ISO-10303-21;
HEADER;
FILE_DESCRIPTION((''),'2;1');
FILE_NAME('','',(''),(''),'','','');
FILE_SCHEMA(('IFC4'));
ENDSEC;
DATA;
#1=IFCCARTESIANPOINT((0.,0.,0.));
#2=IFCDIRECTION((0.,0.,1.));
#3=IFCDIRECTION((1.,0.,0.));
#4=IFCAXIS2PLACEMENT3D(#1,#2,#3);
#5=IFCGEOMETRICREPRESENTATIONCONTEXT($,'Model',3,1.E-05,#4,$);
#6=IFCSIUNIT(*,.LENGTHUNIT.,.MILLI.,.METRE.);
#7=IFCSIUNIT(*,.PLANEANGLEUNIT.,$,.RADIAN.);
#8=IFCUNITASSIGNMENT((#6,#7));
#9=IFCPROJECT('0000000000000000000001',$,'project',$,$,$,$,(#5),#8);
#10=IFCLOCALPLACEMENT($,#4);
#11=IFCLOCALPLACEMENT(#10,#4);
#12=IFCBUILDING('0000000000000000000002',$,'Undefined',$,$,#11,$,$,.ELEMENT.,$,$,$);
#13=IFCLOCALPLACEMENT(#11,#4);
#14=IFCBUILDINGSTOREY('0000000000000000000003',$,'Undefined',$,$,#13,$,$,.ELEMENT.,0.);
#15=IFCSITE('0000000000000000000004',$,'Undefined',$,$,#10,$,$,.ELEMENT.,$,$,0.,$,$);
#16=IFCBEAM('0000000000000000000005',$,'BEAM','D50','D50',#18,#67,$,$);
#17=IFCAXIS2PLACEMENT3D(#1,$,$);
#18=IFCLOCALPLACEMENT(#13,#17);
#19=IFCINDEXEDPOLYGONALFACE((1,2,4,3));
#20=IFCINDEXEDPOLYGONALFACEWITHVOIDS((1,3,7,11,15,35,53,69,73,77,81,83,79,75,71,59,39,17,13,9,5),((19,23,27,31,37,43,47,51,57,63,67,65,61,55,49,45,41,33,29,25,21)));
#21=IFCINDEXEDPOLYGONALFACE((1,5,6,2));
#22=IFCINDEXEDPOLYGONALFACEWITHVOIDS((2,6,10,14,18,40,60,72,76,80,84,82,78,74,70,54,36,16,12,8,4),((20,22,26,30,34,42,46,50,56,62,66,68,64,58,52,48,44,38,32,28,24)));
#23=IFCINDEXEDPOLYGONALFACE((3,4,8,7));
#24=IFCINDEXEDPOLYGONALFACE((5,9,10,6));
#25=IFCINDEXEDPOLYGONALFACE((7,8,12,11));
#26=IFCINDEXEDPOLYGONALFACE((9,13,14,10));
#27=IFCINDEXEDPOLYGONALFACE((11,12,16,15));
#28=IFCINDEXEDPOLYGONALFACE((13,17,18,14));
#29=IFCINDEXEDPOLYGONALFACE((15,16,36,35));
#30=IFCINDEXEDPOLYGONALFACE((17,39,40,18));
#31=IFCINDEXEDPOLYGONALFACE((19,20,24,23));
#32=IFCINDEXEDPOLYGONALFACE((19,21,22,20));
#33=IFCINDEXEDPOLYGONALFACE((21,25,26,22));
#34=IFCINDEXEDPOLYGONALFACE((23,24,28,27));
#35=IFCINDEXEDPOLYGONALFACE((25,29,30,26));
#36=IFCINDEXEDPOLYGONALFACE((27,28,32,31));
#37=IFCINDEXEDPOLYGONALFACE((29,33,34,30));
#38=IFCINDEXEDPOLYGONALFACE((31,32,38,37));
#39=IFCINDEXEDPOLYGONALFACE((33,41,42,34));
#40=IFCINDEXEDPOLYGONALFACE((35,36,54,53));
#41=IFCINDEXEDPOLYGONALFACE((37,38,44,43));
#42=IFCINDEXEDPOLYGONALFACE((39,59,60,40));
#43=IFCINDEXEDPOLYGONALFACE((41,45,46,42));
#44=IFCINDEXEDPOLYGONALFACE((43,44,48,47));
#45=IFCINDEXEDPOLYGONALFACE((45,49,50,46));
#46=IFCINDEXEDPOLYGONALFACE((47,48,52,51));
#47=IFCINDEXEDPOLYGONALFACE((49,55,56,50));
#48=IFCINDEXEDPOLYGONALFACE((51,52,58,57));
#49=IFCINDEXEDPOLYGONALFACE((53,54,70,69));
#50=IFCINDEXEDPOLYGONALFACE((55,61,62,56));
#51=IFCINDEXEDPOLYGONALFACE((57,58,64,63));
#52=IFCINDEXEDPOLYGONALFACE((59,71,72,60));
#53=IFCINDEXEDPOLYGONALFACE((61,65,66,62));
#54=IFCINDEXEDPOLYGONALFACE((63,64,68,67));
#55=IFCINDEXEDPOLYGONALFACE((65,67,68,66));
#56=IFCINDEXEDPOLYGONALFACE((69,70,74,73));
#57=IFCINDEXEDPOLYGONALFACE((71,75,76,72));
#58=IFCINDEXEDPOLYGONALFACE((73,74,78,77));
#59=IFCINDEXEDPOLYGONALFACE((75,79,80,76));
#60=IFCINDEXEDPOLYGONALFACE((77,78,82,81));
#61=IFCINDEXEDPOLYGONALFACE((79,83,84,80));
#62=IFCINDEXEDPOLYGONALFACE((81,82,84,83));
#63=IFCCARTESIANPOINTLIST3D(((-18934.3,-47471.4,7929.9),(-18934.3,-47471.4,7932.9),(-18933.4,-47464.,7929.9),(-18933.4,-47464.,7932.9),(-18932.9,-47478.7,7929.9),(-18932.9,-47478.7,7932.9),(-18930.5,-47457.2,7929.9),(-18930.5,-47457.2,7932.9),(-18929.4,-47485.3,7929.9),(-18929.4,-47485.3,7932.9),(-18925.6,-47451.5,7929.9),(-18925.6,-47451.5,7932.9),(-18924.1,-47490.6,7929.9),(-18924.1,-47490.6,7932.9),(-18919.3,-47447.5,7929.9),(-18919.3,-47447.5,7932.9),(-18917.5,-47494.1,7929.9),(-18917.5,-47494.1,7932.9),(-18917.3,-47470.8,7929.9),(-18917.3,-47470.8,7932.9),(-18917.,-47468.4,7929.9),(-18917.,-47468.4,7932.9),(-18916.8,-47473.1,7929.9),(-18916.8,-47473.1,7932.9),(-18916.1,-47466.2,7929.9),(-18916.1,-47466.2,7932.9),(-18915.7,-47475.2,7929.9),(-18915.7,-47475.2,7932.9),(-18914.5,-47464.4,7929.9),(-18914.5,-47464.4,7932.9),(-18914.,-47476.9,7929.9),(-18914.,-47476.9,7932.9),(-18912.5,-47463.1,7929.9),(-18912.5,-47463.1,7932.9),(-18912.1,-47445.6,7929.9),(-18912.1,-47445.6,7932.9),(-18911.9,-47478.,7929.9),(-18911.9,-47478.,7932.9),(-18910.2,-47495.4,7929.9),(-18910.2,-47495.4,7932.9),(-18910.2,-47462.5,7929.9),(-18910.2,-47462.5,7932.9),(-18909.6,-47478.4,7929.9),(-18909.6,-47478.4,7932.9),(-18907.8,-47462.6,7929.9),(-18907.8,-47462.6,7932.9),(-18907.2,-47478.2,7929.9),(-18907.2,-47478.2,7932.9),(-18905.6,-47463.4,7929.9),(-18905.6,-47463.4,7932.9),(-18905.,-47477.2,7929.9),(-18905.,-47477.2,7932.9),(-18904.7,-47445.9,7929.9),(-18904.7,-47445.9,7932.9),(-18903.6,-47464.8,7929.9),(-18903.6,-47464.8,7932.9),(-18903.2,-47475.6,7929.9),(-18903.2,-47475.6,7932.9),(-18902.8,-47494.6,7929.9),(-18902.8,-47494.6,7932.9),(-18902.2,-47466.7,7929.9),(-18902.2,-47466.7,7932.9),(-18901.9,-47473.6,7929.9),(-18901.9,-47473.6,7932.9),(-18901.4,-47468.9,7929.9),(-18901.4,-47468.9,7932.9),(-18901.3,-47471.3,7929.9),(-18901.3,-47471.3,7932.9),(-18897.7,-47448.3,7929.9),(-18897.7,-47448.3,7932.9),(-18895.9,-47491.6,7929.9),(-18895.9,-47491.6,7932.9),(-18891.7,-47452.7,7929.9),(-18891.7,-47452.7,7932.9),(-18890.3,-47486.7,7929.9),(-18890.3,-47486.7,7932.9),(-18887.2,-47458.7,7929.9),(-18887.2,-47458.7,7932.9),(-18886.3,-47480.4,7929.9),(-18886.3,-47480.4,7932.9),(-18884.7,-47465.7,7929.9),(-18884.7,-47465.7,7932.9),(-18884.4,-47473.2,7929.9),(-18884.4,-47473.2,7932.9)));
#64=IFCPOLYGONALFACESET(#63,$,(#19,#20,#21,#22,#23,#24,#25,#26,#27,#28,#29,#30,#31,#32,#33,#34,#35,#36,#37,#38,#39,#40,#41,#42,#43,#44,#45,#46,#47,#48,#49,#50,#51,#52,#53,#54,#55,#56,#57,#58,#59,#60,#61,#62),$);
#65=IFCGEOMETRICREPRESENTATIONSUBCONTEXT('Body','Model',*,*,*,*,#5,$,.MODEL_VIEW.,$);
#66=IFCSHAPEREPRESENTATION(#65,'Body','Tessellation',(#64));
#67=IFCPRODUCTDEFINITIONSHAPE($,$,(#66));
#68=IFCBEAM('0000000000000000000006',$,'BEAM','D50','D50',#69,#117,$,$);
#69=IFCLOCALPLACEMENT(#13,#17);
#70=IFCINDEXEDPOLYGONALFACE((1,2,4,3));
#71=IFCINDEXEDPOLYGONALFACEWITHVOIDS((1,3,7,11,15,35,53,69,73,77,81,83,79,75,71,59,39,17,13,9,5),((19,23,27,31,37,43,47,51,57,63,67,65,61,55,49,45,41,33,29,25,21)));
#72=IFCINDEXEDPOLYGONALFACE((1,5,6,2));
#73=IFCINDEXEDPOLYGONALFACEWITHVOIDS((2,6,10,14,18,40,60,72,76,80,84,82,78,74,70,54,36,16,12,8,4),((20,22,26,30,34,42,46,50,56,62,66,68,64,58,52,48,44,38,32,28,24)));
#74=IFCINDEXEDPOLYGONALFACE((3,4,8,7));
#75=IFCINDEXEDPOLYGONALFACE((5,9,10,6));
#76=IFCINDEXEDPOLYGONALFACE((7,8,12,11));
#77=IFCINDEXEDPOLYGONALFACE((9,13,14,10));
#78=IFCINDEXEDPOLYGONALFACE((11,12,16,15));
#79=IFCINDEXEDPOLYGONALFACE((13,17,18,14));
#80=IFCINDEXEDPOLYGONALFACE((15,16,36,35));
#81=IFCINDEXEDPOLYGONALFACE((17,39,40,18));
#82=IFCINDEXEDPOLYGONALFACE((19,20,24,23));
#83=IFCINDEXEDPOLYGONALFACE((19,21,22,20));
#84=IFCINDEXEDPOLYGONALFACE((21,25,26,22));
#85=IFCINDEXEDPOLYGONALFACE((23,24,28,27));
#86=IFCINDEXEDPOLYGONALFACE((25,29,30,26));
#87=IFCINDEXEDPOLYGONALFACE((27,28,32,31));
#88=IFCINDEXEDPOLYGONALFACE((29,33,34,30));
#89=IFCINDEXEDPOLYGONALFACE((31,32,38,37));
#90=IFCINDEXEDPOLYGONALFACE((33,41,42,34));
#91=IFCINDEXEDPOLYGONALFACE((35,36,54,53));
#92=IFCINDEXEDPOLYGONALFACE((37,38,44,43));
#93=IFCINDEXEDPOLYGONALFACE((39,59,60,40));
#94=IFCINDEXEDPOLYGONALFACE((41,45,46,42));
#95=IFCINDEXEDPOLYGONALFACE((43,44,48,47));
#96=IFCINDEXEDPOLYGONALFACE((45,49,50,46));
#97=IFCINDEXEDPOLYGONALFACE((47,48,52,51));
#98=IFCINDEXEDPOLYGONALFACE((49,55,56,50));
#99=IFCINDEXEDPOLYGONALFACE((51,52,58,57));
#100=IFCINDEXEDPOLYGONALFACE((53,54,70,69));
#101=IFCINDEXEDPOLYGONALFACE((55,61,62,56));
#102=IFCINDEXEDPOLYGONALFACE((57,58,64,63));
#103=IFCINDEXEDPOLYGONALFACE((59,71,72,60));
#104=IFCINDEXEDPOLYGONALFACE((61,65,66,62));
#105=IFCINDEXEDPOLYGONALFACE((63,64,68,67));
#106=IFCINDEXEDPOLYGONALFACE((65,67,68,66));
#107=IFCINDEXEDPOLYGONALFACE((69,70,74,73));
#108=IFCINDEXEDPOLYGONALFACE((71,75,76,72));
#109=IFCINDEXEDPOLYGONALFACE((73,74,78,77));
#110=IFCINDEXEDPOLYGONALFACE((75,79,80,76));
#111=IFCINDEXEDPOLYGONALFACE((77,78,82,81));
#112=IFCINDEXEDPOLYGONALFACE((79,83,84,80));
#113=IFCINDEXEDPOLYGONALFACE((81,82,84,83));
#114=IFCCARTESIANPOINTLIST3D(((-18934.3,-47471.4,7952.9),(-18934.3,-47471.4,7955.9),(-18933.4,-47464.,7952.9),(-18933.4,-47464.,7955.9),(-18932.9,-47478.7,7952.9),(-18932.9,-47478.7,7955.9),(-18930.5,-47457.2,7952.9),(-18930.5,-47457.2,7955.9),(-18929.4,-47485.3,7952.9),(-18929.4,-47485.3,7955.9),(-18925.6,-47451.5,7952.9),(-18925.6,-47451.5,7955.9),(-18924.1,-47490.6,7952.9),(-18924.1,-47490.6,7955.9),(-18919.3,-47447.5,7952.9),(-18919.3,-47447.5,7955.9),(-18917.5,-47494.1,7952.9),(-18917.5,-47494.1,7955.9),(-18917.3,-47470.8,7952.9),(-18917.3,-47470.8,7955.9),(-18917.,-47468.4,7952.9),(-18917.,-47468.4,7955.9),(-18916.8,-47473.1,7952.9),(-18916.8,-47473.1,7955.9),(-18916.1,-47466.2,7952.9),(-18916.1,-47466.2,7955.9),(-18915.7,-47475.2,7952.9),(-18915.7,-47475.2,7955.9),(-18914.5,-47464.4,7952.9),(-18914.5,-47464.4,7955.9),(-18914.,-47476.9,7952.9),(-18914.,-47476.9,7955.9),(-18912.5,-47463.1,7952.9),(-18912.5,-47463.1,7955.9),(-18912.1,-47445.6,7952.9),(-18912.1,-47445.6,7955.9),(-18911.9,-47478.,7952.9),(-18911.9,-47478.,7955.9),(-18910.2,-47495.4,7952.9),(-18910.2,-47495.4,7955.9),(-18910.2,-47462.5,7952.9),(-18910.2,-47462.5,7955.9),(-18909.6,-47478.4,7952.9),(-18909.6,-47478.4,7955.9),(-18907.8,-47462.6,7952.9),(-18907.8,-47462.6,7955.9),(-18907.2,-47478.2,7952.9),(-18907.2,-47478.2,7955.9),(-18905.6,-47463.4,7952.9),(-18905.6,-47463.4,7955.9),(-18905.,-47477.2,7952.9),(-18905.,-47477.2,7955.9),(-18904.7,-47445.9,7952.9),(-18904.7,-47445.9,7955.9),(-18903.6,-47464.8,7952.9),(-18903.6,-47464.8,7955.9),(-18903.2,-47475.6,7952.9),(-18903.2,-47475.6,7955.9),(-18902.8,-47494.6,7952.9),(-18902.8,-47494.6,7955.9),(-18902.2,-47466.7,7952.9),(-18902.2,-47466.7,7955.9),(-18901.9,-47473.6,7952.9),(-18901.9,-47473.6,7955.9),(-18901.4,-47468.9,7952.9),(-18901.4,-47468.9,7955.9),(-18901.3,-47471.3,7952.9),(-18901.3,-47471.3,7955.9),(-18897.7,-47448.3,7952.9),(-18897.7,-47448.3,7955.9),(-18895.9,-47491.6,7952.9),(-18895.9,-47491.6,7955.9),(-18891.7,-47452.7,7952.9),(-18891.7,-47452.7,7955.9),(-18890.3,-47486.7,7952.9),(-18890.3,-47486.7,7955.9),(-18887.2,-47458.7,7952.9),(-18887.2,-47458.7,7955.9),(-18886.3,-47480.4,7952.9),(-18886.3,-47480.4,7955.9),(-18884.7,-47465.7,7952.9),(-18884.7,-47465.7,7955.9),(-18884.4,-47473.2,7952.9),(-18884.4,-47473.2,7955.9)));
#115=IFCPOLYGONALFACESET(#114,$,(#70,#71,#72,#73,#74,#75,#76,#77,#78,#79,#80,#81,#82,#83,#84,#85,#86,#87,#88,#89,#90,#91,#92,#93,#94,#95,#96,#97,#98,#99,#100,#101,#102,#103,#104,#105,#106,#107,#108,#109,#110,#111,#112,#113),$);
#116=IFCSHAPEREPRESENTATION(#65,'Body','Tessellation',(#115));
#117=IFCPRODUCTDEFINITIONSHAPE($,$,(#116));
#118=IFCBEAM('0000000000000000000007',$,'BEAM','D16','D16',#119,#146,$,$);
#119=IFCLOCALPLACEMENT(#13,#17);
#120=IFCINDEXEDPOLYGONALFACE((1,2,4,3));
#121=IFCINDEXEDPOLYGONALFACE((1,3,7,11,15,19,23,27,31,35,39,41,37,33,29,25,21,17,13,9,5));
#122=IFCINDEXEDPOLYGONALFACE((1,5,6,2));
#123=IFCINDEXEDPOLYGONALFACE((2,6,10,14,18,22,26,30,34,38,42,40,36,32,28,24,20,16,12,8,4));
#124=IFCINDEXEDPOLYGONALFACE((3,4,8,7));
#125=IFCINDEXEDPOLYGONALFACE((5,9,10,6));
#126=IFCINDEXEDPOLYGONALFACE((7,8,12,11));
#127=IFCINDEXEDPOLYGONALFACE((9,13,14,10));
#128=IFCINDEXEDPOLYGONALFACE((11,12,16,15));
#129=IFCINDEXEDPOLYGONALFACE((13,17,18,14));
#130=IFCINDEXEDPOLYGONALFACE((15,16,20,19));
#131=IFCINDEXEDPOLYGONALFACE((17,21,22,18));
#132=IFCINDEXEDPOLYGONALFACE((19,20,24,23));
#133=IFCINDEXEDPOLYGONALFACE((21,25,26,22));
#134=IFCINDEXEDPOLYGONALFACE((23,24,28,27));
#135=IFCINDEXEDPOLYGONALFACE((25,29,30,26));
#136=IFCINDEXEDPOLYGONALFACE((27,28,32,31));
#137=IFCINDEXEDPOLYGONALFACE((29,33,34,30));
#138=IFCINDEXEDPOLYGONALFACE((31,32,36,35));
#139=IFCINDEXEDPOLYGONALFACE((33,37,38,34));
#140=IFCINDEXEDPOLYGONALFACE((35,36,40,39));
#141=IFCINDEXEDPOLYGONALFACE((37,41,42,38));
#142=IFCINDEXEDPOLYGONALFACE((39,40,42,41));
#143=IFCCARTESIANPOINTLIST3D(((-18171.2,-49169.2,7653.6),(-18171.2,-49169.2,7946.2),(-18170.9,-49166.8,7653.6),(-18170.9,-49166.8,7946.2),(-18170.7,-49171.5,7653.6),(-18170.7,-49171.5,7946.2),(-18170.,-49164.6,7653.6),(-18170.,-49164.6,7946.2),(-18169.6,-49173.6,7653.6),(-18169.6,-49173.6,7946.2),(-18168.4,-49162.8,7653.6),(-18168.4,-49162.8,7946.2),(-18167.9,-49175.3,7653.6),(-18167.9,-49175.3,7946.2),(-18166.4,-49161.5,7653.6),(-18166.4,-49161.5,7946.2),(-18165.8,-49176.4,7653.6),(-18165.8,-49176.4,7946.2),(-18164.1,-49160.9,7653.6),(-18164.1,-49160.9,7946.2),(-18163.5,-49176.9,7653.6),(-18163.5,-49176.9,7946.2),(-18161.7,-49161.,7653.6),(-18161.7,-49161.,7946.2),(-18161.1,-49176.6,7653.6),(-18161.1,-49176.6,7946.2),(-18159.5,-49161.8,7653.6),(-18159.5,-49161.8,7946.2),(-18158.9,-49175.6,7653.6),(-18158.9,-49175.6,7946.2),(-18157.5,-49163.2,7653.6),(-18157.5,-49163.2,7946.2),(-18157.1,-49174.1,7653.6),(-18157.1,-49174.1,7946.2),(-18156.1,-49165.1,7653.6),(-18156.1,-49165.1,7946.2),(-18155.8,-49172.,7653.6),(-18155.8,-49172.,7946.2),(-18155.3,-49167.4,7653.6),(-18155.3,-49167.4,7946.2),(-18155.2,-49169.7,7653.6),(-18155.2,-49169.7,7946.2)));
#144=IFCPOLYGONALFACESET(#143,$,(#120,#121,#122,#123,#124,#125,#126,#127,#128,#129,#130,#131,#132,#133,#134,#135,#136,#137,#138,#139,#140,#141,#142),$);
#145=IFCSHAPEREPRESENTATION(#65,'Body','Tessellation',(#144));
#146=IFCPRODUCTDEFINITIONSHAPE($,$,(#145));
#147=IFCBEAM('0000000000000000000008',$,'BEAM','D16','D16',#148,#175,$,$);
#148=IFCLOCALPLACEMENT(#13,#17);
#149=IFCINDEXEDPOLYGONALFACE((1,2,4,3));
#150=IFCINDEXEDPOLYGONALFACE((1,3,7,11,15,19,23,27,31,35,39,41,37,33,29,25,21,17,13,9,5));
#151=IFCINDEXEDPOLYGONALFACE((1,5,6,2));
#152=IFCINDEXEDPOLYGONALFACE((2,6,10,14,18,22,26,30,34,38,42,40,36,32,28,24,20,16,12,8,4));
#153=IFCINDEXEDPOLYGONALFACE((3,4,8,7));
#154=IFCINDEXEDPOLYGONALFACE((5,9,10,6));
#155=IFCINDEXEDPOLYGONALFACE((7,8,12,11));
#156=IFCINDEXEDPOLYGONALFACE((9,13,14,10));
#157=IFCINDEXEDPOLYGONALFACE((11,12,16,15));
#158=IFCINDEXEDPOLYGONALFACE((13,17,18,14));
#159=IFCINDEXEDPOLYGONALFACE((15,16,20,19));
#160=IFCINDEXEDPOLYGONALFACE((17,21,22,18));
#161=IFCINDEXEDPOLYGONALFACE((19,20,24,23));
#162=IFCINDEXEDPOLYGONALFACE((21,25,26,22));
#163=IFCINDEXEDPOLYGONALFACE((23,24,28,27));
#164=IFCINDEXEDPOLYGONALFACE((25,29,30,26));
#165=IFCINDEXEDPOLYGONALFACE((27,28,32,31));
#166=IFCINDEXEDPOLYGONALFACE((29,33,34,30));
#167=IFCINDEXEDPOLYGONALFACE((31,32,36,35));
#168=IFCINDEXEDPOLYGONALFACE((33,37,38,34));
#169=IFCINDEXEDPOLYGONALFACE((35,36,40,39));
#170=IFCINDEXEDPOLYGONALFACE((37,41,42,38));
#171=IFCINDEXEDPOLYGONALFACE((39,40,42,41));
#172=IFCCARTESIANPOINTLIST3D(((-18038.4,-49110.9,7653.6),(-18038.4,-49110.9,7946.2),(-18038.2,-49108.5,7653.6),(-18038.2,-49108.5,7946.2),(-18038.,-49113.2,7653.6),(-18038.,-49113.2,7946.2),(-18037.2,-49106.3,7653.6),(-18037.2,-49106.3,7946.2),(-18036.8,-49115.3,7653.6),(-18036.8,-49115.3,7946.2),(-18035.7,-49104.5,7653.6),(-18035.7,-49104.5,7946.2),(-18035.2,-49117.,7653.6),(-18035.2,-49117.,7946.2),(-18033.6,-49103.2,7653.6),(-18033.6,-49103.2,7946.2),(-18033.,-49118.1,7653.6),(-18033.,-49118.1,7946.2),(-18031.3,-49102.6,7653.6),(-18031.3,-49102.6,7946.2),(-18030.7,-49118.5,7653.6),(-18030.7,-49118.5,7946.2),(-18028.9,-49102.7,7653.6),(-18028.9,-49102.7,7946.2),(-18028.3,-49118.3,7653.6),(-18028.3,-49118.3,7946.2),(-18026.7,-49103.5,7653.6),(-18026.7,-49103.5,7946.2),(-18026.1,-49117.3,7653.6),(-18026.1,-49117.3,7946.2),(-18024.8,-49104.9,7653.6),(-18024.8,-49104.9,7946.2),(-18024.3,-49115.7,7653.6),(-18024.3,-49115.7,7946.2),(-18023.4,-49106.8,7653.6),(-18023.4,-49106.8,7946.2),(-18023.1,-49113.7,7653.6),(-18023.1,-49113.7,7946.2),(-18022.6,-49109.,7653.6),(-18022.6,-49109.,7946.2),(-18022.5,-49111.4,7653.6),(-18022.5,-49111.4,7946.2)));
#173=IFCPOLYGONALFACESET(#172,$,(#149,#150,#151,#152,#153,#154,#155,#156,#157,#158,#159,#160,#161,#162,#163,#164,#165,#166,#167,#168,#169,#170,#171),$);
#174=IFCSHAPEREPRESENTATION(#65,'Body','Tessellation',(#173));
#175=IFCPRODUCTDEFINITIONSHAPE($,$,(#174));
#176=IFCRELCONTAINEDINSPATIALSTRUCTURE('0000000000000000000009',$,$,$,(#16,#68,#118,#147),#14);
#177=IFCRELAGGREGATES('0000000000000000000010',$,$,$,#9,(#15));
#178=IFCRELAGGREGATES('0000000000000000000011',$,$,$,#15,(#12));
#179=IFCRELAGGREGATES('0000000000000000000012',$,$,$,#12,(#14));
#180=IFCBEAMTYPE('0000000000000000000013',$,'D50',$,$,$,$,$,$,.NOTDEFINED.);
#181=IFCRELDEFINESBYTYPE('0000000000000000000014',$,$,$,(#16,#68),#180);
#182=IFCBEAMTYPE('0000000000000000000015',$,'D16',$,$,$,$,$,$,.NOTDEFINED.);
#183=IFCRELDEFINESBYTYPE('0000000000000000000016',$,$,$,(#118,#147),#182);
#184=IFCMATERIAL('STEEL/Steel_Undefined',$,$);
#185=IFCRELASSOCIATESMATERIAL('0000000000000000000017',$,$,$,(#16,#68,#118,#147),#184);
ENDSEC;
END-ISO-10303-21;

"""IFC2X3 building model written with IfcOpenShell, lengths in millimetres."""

from ifc_helpers import new_model, si_unit, frame, origin_with_axes, origin_2d_with_axis, place, context, subcontext, project, spatial, circle, extrude, material, type_object, element, save


model = new_model("IFC2X3")

# Units and contexts
model_context = context("Model", 3, precision=1e-05, world=origin_with_axes())
body_context = subcontext(model_context, "Body", "Model", "MODEL_VIEW")
ifc_project = project(units=[si_unit("LENGTHUNIT", "METRE", prefix="MILLI"), si_unit("PLANEANGLEUNIT", "RADIAN")], contexts=[model_context])

# Site, building, storey
site_placement = place(None, origin_with_axes())
site = spatial("IfcSite", under=ifc_project, at=site_placement, Name="Undefined", CompositionType="ELEMENT", RefElevation=0.0)
building_placement = place(site_placement, origin_with_axes())
building = spatial("IfcBuilding", under=site, at=building_placement, Name="Undefined", CompositionType="ELEMENT")
storey_placement = place(building_placement, origin_with_axes())
storey = spatial("IfcBuildingStorey", under=building, at=storey_placement, Name="Undefined", CompositionType="ELEMENT", Elevation=0.0)

# Beams, openings
ifc_material = material(Name="STEEL/Steel_Undefined")
beam_type_1 = type_object("IfcBeamType", Name="D50", PredefinedType="NOTDEFINED")
beam_1_placement = place(storey_placement, frame((-18909.3, -47470.4, 7932.9), z_axis=(-0.915553, -0.402197, 0.0), x_axis=(0.0, 0.0, -1.0)))
beam_1 = element("IfcBeam", 1, at=beam_1_placement, inside=storey, type_object=beam_type_1, material=ifc_material, Name="BEAM", Description="D50", ObjectType="D50", context=body_context, shape_type="SweptSolid", body=[
    extrude(circle(Radius=25.0, at=origin_2d_with_axis()), frame((3.0, 0.0, 0.0), z_axis=(-1.0, 0.0, 0.0), x_axis=(0.0, -1.0, 0.0)), (0.0, 0.0, 1.0), 3.0),
])
opening_1_placement = place(storey_placement, frame((-18909.3, -47470.4, 7932.9), z_axis=(-0.915553, -0.402197, 0.0), x_axis=(0.0, 0.0, -1.0)))
element("IfcOpeningElement", 2, at=opening_1_placement, cuts=beam_1, ObjectType="Recess", context=body_context, shape_type="SweptSolid", body=[
    extrude(circle(Radius=8.0, at=origin_2d_with_axis()), frame((245.5, 0.0, 0.0), z_axis=(-1.0, 0.0, 0.0), x_axis=(0.0, -1.0, 0.0)), (0.0, 0.0, 1.0), 292.6),
])
beam_2_placement = place(storey_placement, frame((-18909.3, -47470.4, 7955.9), z_axis=(-0.915553, -0.402197, 0.0), x_axis=(0.0, 0.0, -1.0)))
beam_2 = element("IfcBeam", 3, at=beam_2_placement, inside=storey, type_object=beam_type_1, material=ifc_material, Name="BEAM", Description="D50", ObjectType="D50", context=body_context, shape_type="SweptSolid", body=[
    extrude(circle(Radius=25.0, at=origin_2d_with_axis()), frame((3.0, 0.0, 0.0), z_axis=(-1.0, 0.0, 0.0), x_axis=(0.0, -1.0, 0.0)), (0.0, 0.0, 1.0), 3.0),
])
opening_2_placement = place(storey_placement, frame((-18909.3, -47470.4, 7955.9), z_axis=(-0.915553, -0.402197, 0.0), x_axis=(0.0, 0.0, -1.0)))
element("IfcOpeningElement", 4, at=opening_2_placement, cuts=beam_2, ObjectType="Recess", context=body_context, shape_type="SweptSolid", body=[
    extrude(circle(Radius=8.0, at=origin_2d_with_axis()), frame((268.5, 0.0, 0.0), z_axis=(-1.0, 0.0, 0.0), x_axis=(0.0, -1.0, 0.0)), (0.0, 0.0, 1.0), 292.6),
])

# Beams
beam_type_2 = type_object("IfcBeamType", Name="D16", PredefinedType="NOTDEFINED")
for number, where, z_axis, x_axis, name in (
    (5, (-18163.2, -49168.9, 7946.2), (-0.915553, -0.402197, 0.0), (0.0, 0.0, -1.0), "BEAM"),
    (6, (-18030.4, -49110.5, 7946.2), (-0.915553, -0.402197, 0.0), (0.0, 0.0, -1.0), "BEAM"),
):
    element("IfcBeam", number, at=place(storey_placement, frame(where, z_axis=z_axis, x_axis=x_axis)), inside=storey, type_object=beam_type_2, material=ifc_material, Name=name, Description="D16", ObjectType="D16", context=body_context, shape_type="SweptSolid", body=[
        extrude(circle(Radius=8.0, at=origin_2d_with_axis()), frame((292.6, 0.0, 0.0), z_axis=(-1.0, 0.0, 0.0), x_axis=(0.0, -1.0, 0.0)), (0.0, 0.0, 1.0), 292.6),
    ])

save(model, "model.ifc")
